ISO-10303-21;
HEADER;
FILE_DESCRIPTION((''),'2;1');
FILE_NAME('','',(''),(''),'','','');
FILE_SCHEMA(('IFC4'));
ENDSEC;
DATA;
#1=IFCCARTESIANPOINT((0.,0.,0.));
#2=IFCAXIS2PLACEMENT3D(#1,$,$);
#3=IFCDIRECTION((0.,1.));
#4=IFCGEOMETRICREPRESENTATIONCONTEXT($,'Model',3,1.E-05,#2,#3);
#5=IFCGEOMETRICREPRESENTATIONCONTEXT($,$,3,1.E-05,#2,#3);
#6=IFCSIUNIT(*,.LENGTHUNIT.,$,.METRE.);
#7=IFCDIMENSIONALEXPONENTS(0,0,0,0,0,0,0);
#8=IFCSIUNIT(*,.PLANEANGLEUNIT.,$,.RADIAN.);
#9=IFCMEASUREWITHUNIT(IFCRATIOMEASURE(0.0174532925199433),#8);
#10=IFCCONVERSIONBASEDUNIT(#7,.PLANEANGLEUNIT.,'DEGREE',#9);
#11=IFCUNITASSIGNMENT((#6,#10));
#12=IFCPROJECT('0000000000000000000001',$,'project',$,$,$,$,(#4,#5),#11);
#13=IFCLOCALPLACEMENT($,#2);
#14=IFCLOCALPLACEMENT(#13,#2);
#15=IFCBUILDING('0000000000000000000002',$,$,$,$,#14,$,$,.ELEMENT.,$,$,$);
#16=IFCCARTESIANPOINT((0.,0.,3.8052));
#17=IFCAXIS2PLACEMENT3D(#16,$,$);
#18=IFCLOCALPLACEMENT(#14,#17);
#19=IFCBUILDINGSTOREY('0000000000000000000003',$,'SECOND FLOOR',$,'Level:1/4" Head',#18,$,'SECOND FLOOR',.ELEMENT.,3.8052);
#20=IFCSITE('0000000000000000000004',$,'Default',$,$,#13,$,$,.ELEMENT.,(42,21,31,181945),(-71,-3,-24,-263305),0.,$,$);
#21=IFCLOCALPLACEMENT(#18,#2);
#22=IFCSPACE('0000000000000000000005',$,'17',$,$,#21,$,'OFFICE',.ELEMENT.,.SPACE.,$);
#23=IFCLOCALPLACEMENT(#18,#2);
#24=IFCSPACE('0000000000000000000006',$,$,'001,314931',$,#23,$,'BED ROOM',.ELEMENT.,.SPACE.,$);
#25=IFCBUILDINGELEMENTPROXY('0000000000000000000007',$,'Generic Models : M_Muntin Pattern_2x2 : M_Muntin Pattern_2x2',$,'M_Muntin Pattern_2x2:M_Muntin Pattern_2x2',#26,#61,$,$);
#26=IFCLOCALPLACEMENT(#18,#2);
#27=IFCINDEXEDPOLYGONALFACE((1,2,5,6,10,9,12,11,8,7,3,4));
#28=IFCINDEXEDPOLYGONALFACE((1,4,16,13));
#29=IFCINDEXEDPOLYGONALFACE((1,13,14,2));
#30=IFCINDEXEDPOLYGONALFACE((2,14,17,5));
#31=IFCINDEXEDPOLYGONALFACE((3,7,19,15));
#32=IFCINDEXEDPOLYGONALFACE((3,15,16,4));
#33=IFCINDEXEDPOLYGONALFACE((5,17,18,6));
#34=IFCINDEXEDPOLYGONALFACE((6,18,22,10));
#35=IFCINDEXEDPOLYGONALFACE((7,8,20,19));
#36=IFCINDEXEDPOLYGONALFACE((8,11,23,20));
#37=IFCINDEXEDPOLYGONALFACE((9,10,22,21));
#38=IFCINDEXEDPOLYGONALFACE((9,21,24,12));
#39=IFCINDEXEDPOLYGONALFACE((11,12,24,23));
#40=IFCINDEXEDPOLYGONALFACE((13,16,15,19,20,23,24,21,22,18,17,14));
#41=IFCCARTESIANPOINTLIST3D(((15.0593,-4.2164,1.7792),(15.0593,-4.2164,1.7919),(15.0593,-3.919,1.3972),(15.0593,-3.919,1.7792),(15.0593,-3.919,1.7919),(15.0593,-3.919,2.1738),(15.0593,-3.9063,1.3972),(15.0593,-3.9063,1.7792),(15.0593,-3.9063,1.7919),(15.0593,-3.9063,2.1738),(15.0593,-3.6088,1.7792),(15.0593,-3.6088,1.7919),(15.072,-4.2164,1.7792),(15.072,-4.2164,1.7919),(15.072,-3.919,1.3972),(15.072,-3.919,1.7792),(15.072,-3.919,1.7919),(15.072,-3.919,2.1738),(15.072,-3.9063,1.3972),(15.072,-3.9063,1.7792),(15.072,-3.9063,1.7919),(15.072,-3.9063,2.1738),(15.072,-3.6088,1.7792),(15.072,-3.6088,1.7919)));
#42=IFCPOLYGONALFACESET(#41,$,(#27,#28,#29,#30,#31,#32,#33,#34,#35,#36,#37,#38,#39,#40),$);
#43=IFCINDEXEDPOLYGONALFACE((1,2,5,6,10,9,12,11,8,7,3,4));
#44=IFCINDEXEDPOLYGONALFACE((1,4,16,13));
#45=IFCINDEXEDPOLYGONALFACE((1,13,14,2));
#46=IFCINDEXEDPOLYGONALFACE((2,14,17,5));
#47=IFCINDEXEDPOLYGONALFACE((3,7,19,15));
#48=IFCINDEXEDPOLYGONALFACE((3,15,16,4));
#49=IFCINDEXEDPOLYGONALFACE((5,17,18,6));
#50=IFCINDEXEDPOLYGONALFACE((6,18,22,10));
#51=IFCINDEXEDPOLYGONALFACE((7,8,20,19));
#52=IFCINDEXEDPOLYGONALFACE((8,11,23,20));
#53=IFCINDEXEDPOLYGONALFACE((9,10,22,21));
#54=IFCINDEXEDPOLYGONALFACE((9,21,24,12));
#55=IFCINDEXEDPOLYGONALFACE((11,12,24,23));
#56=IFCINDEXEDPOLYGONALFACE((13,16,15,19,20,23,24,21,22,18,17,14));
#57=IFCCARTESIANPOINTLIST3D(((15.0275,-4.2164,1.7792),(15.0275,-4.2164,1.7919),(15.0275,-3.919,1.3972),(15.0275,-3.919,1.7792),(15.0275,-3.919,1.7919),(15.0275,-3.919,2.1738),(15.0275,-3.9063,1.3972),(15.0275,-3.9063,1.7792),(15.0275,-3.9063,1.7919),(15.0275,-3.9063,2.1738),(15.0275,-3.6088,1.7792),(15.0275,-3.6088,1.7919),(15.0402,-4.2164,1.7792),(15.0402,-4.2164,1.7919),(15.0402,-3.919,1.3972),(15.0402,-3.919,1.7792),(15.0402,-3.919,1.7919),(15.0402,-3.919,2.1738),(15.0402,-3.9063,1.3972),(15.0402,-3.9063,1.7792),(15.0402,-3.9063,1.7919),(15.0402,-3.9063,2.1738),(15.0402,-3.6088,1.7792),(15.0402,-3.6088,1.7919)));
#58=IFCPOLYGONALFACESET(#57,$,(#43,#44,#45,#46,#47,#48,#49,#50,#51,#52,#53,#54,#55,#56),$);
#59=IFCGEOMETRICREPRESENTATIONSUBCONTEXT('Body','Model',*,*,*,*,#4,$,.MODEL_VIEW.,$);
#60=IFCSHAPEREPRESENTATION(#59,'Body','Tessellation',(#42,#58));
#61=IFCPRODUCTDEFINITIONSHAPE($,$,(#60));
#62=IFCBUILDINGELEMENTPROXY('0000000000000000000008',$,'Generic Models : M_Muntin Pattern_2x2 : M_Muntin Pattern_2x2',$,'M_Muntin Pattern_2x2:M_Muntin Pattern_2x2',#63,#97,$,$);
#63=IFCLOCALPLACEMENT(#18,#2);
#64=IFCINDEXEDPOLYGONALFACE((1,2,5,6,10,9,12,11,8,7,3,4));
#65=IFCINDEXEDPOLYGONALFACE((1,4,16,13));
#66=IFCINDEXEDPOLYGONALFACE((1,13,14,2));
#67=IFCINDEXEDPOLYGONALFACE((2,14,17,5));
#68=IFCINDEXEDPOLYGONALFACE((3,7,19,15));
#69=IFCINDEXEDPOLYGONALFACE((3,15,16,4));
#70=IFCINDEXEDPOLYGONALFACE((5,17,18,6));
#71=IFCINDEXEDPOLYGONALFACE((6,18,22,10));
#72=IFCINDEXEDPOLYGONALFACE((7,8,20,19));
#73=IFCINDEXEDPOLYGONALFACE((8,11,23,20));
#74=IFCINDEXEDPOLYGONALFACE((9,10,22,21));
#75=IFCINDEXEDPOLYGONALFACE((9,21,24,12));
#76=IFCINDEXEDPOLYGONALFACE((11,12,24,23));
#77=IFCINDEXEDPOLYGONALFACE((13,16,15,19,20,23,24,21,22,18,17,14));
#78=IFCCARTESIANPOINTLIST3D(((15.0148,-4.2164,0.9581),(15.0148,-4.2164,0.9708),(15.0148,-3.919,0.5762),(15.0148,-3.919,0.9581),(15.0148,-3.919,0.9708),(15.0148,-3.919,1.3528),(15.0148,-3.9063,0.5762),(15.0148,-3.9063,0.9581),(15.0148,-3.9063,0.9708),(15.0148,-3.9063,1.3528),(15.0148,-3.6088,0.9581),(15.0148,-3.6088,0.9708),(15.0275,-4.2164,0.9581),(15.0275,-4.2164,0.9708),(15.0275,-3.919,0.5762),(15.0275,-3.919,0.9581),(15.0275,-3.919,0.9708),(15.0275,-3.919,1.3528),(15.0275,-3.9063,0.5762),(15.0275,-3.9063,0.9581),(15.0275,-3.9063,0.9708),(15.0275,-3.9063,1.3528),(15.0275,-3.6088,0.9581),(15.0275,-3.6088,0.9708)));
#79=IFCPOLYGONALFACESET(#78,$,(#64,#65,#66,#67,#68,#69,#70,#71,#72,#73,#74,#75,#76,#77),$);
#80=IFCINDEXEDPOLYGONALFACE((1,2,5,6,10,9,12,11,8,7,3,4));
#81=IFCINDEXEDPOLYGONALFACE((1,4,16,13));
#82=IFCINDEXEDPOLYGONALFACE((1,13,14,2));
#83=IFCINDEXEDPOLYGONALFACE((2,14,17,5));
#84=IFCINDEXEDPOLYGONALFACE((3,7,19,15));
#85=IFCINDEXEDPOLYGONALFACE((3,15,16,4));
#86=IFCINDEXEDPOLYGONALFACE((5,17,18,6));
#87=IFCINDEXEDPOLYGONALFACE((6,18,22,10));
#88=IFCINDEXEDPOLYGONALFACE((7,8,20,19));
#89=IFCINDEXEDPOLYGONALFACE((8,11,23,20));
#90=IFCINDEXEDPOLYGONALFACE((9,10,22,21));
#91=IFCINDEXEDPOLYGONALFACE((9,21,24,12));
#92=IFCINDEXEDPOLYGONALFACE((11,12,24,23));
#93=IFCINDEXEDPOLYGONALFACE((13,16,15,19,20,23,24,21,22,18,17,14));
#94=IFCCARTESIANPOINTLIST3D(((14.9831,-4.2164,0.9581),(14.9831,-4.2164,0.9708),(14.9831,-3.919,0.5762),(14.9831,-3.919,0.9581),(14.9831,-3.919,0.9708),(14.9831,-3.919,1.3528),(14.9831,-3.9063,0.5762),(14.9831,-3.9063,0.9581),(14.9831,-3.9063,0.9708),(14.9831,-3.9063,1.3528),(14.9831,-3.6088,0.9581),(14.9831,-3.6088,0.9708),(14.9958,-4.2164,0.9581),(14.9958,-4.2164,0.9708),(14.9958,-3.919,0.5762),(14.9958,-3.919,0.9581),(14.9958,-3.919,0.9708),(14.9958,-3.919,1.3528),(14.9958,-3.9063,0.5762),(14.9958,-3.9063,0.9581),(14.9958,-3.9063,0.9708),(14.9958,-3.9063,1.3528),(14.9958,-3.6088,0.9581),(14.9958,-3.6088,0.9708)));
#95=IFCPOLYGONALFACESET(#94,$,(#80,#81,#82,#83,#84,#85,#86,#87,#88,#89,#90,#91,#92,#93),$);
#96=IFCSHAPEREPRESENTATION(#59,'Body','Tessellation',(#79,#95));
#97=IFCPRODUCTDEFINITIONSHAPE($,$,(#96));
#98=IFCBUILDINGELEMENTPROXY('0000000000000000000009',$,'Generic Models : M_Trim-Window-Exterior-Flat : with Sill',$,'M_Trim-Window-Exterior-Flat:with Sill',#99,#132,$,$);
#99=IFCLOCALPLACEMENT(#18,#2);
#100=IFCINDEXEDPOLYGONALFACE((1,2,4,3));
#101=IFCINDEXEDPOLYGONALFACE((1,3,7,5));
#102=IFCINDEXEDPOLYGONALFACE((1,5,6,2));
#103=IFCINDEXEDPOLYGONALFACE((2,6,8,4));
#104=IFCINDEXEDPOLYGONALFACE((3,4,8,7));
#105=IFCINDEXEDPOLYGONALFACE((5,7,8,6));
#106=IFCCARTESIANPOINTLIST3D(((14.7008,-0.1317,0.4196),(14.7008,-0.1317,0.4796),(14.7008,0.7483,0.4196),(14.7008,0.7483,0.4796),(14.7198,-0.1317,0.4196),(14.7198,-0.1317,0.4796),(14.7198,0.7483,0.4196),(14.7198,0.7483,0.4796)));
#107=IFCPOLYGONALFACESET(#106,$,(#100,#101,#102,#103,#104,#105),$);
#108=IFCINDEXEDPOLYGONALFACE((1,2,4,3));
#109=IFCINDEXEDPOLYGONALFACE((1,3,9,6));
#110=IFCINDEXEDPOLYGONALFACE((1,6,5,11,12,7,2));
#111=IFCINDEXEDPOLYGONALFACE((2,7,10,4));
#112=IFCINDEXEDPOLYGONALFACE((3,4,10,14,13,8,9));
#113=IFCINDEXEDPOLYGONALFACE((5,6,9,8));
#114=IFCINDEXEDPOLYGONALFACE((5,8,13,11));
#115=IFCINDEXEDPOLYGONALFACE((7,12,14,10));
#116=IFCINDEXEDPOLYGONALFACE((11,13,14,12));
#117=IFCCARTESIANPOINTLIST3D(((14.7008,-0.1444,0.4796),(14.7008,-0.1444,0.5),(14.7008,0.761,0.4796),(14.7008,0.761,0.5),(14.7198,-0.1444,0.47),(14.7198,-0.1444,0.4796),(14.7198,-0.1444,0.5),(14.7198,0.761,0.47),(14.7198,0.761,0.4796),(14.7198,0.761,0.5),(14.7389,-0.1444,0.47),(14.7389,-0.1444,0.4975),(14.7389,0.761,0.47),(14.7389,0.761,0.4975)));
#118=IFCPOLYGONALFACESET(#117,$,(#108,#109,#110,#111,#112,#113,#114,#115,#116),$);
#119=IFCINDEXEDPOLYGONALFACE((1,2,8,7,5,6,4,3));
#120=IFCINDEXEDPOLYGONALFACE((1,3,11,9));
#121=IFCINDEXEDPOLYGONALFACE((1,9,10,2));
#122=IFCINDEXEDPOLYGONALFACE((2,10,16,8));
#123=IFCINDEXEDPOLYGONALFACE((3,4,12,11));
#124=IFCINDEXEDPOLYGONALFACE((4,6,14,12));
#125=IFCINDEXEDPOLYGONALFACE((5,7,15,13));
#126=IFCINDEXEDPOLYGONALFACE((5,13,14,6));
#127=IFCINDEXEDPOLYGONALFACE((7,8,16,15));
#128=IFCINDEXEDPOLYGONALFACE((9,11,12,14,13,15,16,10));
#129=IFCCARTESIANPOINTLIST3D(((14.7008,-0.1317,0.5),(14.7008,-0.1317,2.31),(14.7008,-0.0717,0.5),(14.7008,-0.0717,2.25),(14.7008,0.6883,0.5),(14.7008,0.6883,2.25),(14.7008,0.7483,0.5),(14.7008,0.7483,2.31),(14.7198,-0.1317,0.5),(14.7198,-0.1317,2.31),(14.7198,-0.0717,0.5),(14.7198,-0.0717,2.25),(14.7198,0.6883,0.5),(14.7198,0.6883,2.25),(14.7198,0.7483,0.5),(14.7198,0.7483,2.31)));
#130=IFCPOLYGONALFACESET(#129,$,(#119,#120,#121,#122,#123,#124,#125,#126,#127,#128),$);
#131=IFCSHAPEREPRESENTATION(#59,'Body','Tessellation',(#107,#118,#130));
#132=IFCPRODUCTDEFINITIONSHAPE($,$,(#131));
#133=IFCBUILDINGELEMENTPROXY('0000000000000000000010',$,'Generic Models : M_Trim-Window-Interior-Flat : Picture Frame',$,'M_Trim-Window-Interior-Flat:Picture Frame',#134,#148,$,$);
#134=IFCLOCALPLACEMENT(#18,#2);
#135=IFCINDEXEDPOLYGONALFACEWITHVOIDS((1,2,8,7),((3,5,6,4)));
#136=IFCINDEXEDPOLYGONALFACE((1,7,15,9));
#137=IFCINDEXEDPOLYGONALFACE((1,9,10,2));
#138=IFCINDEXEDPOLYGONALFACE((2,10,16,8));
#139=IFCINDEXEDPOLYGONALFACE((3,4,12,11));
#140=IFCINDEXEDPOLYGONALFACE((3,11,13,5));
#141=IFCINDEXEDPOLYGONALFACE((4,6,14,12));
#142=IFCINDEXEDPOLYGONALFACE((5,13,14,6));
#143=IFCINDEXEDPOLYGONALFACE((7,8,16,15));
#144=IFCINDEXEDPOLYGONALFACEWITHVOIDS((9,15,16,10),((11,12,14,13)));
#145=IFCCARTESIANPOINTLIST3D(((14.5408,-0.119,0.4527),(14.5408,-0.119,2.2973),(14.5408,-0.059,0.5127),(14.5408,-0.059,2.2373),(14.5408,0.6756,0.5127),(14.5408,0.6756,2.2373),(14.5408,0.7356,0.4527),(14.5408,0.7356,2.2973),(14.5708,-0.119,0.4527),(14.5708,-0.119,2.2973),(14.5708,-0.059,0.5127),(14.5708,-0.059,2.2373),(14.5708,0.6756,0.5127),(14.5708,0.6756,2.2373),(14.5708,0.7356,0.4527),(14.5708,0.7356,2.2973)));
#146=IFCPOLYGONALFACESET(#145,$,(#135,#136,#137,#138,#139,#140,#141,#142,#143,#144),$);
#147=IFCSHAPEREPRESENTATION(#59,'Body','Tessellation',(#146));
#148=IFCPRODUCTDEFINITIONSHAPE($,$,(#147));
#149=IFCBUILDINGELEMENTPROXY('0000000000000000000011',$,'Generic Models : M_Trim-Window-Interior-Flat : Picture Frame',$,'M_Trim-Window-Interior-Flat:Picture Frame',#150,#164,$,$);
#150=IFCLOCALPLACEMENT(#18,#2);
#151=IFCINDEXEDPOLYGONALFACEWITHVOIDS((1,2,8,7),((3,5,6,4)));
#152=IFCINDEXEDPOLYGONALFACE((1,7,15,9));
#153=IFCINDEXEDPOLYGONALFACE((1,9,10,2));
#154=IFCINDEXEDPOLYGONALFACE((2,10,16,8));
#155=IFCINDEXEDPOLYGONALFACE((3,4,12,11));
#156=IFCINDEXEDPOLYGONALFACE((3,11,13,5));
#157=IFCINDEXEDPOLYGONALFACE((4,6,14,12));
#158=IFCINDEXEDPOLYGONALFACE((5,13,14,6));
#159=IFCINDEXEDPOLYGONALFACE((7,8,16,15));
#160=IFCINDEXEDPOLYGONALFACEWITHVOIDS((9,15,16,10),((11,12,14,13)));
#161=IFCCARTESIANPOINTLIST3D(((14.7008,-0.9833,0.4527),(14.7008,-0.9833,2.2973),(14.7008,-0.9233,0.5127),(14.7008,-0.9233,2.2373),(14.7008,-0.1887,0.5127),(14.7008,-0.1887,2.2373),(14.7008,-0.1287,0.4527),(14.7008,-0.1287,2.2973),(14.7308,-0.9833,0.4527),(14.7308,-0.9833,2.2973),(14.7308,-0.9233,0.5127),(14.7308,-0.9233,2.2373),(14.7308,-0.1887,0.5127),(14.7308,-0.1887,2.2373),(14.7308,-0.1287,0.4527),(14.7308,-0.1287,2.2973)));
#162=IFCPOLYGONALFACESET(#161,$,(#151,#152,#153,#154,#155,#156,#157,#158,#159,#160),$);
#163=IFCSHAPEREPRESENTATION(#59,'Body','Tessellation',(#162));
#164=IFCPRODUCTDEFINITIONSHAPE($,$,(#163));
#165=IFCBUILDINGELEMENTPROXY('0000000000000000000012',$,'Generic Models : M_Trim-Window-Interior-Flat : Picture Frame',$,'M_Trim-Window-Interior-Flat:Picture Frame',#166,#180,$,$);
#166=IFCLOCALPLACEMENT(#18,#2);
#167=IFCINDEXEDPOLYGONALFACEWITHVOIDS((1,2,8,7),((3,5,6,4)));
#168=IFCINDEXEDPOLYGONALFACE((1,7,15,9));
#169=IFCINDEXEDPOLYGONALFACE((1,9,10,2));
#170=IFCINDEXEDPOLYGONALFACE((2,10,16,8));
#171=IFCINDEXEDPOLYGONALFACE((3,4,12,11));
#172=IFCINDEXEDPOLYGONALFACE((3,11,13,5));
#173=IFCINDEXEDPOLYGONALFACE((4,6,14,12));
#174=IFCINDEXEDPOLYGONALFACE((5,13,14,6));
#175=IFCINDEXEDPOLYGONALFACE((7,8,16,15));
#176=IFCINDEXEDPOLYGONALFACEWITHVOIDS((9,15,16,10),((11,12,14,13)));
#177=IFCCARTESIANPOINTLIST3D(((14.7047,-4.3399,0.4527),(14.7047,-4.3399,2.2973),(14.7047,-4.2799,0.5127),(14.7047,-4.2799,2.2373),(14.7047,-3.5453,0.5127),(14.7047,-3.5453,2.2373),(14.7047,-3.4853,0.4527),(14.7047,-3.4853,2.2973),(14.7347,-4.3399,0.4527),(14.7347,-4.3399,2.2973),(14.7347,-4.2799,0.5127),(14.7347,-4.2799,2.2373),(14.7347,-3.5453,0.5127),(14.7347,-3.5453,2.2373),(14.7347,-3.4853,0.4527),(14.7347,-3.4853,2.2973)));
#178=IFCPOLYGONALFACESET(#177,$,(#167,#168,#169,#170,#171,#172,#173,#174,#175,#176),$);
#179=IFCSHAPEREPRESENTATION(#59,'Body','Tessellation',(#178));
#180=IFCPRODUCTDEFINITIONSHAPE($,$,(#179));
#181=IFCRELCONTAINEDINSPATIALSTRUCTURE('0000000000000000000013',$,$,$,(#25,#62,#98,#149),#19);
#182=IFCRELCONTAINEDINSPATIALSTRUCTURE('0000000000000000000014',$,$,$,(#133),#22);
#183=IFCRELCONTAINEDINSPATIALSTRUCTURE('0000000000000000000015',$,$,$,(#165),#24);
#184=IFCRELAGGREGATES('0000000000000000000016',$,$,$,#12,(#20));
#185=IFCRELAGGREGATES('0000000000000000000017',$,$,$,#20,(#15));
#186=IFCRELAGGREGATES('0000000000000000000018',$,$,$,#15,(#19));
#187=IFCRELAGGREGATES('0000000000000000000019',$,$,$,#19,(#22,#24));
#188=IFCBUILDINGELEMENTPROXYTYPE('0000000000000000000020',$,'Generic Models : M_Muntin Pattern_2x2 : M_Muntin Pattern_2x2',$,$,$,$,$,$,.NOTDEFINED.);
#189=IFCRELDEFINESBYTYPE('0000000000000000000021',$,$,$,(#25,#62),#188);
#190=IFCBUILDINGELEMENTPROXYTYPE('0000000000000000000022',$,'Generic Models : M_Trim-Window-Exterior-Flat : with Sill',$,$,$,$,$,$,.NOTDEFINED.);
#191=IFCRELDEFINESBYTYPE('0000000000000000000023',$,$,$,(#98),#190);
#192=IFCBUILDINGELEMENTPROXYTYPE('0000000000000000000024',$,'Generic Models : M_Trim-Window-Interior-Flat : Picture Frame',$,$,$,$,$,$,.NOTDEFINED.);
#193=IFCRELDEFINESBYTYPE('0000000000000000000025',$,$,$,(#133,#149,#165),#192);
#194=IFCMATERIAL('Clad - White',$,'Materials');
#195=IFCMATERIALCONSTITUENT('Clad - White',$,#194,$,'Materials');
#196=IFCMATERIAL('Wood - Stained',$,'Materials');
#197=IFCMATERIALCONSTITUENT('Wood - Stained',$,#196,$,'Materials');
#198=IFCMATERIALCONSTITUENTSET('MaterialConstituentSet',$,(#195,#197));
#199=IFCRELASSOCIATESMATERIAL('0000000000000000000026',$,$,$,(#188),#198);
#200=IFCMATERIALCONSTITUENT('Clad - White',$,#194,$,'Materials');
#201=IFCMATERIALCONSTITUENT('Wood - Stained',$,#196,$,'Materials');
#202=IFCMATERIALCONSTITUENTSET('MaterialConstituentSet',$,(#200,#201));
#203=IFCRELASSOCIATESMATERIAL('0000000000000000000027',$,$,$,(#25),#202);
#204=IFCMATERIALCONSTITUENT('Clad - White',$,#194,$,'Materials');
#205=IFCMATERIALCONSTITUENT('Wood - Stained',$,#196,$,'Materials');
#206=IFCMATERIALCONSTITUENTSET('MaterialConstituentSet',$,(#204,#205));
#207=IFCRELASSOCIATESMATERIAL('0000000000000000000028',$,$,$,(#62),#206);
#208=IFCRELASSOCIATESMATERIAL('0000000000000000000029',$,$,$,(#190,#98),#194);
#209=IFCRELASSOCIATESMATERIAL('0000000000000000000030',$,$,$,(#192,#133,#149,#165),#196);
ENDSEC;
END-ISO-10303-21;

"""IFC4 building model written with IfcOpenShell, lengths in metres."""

from ifc_helpers import new_model, entity, si_unit, converted_unit, direction, frame, origin, origin_2d_with_axis, place, context, subcontext, project, spatial, polyline, rectangle, outline, extrude, source, transform, mapped, material, constituent, constituent_set, type_object, type_shapes, element, save


model = new_model("IFC4")

# Units and contexts
model_context = context("Model", 3, precision=1e-05, world=origin(), true_north=direction((0.0, 1.0)))
context_of_model = context(None, 3, precision=1e-05, world=origin(), true_north=direction((0.0, 1.0)))
body_context = subcontext(model_context, "Body", "Model", "MODEL_VIEW")
ifc_project = project(units=[si_unit("LENGTHUNIT", "METRE"), converted_unit("PLANEANGLEUNIT", "DEGREE", entity("IfcRatioMeasure", 0.0174532925199433), si_unit("PLANEANGLEUNIT", "RADIAN"), dimensions=[0, 0, 0, 0, 0, 0, 0])], contexts=[model_context, context_of_model])

# Site, building, storey
site_placement = place(None, origin())
site = spatial("IfcSite", under=ifc_project, at=site_placement, Name="Default", CompositionType="ELEMENT", RefLatitude=(42, 21, 31, 181945), RefLongitude=(-71, -3, -24, -263305), RefElevation=0.0)
building_placement = place(site_placement, origin())
building = spatial("IfcBuilding", under=site, at=building_placement, CompositionType="ELEMENT")
storey_placement = place(building_placement, frame((0.0, 0.0, 3.8052)))
storey = spatial("IfcBuildingStorey", under=building, at=storey_placement, Name="SECOND FLOOR", ObjectType="Level:1/4\" Head", LongName="SECOND FLOOR", CompositionType="ELEMENT", Elevation=3.8052)

# Shared definitions
ifc_material_1 = material(Name="Wood - Stained", Category="Materials")

# Building element proxies
ifc_material_2 = material(Name="Clad - White", Category="Materials")
ifc_constituent_1 = constituent(ifc_material_2, Name="Clad - White", Category="Materials")
ifc_constituent_2 = constituent(ifc_material_1, Name="Wood - Stained", Category="Materials")
ifc_constituent_set_1 = constituent_set(constituents=[ifc_constituent_1, ifc_constituent_2], Name="MaterialConstituentSet")
building_element_proxy_type_1 = type_object("IfcBuildingElementProxyType", Name="Generic Models : M_Muntin Pattern_2x2 : M_Muntin Pattern_2x2", PredefinedType="NOTDEFINED", material=ifc_constituent_set_1)
shared_shape_1 = source(origin(), body_context, "Body", "SweptSolid", [
    extrude(outline(polyline([(0.0064, -0.0064), (0.3883, -0.0064), (0.3883, 0.0063), (0.0064, 0.0063), (0.0064, 0.3038), (-0.0063, 0.3038), (-0.0063, 0.0063), (-0.3883, 0.0063), (-0.3883, -0.0064), (-0.0063, -0.0064), (-0.0063, -0.3038), (0.0064, -0.3038), (0.0064, -0.0064)])), frame((0.0, 0.0095, 0.3883), z_axis=(0.0, 1.0, 0.0), x_axis=(0.0, 0.0, 1.0)), (0.0, 0.0, 1.0), 0.0127),
    extrude(outline(polyline([(0.0064, -0.0064), (0.3883, -0.0064), (0.3883, 0.0063), (0.0064, 0.0063), (0.0064, 0.3038), (-0.0063, 0.3038), (-0.0063, 0.0063), (-0.3883, 0.0063), (-0.3883, -0.0064), (-0.0063, -0.0064), (-0.0063, -0.3038), (0.0064, -0.3038), (0.0064, -0.0064)])), frame((0.0, -0.0222, 0.3883), z_axis=(0.0, 1.0, 0.0), x_axis=(0.0, 0.0, 1.0)), (0.0, 0.0, 1.0), 0.0127),
])
type_shapes(building_element_proxy_type_1, [shared_shape_1])
ifc_constituent_3 = constituent(ifc_material_2, Name="Clad - White", Category="Materials")
ifc_constituent_4 = constituent(ifc_material_1, Name="Wood - Stained", Category="Materials")
ifc_constituent_set_2 = constituent_set(constituents=[ifc_constituent_3, ifc_constituent_4], Name="MaterialConstituentSet")
proxy_1_placement = place(storey_placement, frame((15.0498, -3.9126, 1.3972), z_axis=(0.0, 0.0, 1.0), x_axis=(0.0, -1.0, 0.0)))
element("IfcBuildingElementProxy", 1, at=proxy_1_placement, inside=storey, type_object=building_element_proxy_type_1, material=ifc_constituent_set_2, Name="Generic Models : M_Muntin Pattern_2x2 : M_Muntin Pattern_2x2", ObjectType="M_Muntin Pattern_2x2:M_Muntin Pattern_2x2", context=body_context, shape_type="MappedRepresentation", body=[
    mapped(shared_shape_1, transform((0.0, 0.0, 0.0), scale=1.0)),
])
ifc_constituent_5 = constituent(ifc_material_2, Name="Clad - White", Category="Materials")
ifc_constituent_6 = constituent(ifc_material_1, Name="Wood - Stained", Category="Materials")
ifc_constituent_set_3 = constituent_set(constituents=[ifc_constituent_5, ifc_constituent_6], Name="MaterialConstituentSet")
proxy_2_placement = place(storey_placement, frame((15.0053, -3.9126, 0.5762), z_axis=(0.0, 0.0, 1.0), x_axis=(0.0, -1.0, 0.0)))
element("IfcBuildingElementProxy", 2, at=proxy_2_placement, inside=storey, type_object=building_element_proxy_type_1, material=ifc_constituent_set_3, Name="Generic Models : M_Muntin Pattern_2x2 : M_Muntin Pattern_2x2", ObjectType="M_Muntin Pattern_2x2:M_Muntin Pattern_2x2", context=body_context, shape_type="MappedRepresentation", body=[
    mapped(shared_shape_1, transform((0.0, 0.0, 0.0), scale=1.0)),
])
building_element_proxy_type_2 = type_object("IfcBuildingElementProxyType", Name="Generic Models : M_Trim-Window-Exterior-Flat : with Sill", PredefinedType="NOTDEFINED", material=ifc_material_2)
shared_shape_2 = source(origin(), body_context, "Body", "SweptSolid", [
    extrude(rectangle(XDim=0.88, YDim=0.06, at=origin_2d_with_axis()), frame((0.0, -1.8004, 0.0), z_axis=(0.0, 0.0, 1.0), x_axis=(-1.0, 0.0, 0.0)), (0.0, 0.0, 1.0), 0.0191),
    extrude(outline(polyline([(-0.019, -0.0152), (0.0, -0.0152), (0.0, -0.0057), (0.019, -0.0057), (0.019, 0.0148), (0.0, 0.0148), (-0.019, 0.0123), (-0.019, -0.0152)])), frame((-0.4527, -1.7648, 0.019), z_axis=(1.0, 0.0, 0.0), x_axis=(0.0, 0.0, -1.0)), (0.0, 0.0, 1.0), 0.9054),
    extrude(outline(polyline([(-0.92, -0.44), (0.89, -0.44), (0.89, -0.38), (-0.86, -0.38), (-0.86, 0.38), (0.89, 0.38), (0.89, 0.44), (-0.92, 0.44), (-0.92, -0.44)])), frame((0.0, -0.86, 0.0), z_axis=(0.0, 0.0, 1.0), x_axis=(0.0, -1.0, 0.0)), (0.0, 0.0, 1.0), 0.0191),
])
type_shapes(building_element_proxy_type_2, [shared_shape_2])
proxy_3_placement = place(storey_placement, frame((14.7008, 0.3083, 2.25), z_axis=(1.0, 0.0, 0.0), x_axis=(0.0, 1.0, 0.0)))
element("IfcBuildingElementProxy", 3, at=proxy_3_placement, inside=storey, type_object=building_element_proxy_type_2, material=ifc_material_2, Name="Generic Models : M_Trim-Window-Exterior-Flat : with Sill", ObjectType="M_Trim-Window-Exterior-Flat:with Sill", context=body_context, shape_type="MappedRepresentation", body=[
    mapped(shared_shape_2, transform((0.0, 0.0, 0.0), scale=1.0)),
])

# Shared definitions
space_1_placement = place(storey_placement, origin())
space_1 = spatial("IfcSpace", under=storey, at=space_1_placement, Name="17", LongName="OFFICE", CompositionType="ELEMENT", PredefinedType="SPACE")

# Building element proxies
building_element_proxy_type_3 = type_object("IfcBuildingElementProxyType", Name="Generic Models : M_Trim-Window-Interior-Flat : Picture Frame", PredefinedType="NOTDEFINED", material=ifc_material_1)
shared_shape_3 = source(origin(), body_context, "Body", "SweptSolid", [
    extrude(outline(polyline([(-0.4273, -0.9223), (0.4273, -0.9223), (0.4273, 0.9223), (-0.4273, 0.9223), (-0.4273, -0.9223)]), holes=[polyline([(-0.3673, -0.8623), (-0.3673, 0.8623), (0.3673, 0.8623), (0.3673, -0.8623), (-0.3673, -0.8623)])]), frame((0.0, -0.875, 0.0), z_axis=(0.0, 0.0, 1.0), x_axis=(-1.0, 0.0, 0.0)), (0.0, 0.0, 1.0), 0.03),
])
type_shapes(building_element_proxy_type_3, [shared_shape_3])
proxy_4_placement = place(space_1_placement, frame((14.5708, 0.3083, 2.25), z_axis=(-1.0, 0.0, 0.0), x_axis=(0.0, -1.0, 0.0)))
element("IfcBuildingElementProxy", 4, at=proxy_4_placement, inside=space_1, type_object=building_element_proxy_type_3, material=ifc_material_1, Name="Generic Models : M_Trim-Window-Interior-Flat : Picture Frame", ObjectType="M_Trim-Window-Interior-Flat:Picture Frame", context=body_context, shape_type="MappedRepresentation", body=[
    mapped(shared_shape_3, transform((0.0, 0.0, 0.0), scale=1.0)),
])
proxy_5_placement = place(storey_placement, frame((14.7008, -0.556, 2.25), z_axis=(1.0, 0.0, 0.0), x_axis=(0.0, 1.0, 0.0)))
element("IfcBuildingElementProxy", 5, at=proxy_5_placement, inside=storey, type_object=building_element_proxy_type_3, material=ifc_material_1, Name="Generic Models : M_Trim-Window-Interior-Flat : Picture Frame", ObjectType="M_Trim-Window-Interior-Flat:Picture Frame", context=body_context, shape_type="MappedRepresentation", body=[
    mapped(shared_shape_3, transform((0.0, 0.0, 0.0), scale=1.0)),
])

# Shared definitions
space_2_placement = place(storey_placement, origin())
space_2 = spatial("IfcSpace", under=storey, at=space_2_placement, Description="001,314931", LongName="BED ROOM", CompositionType="ELEMENT", PredefinedType="SPACE")

# Building element proxy
proxy_6_placement = place(space_2_placement, frame((14.7347, -3.9126, 2.25), z_axis=(-1.0, 0.0, 0.0), x_axis=(0.0, -1.0, 0.0)))
element("IfcBuildingElementProxy", 6, at=proxy_6_placement, inside=space_2, type_object=building_element_proxy_type_3, material=ifc_material_1, Name="Generic Models : M_Trim-Window-Interior-Flat : Picture Frame", ObjectType="M_Trim-Window-Interior-Flat:Picture Frame", context=body_context, shape_type="MappedRepresentation", body=[
    mapped(shared_shape_3, transform((0.0, 0.0, 0.0), scale=1.0)),
])

save(model, "model.ifc")
